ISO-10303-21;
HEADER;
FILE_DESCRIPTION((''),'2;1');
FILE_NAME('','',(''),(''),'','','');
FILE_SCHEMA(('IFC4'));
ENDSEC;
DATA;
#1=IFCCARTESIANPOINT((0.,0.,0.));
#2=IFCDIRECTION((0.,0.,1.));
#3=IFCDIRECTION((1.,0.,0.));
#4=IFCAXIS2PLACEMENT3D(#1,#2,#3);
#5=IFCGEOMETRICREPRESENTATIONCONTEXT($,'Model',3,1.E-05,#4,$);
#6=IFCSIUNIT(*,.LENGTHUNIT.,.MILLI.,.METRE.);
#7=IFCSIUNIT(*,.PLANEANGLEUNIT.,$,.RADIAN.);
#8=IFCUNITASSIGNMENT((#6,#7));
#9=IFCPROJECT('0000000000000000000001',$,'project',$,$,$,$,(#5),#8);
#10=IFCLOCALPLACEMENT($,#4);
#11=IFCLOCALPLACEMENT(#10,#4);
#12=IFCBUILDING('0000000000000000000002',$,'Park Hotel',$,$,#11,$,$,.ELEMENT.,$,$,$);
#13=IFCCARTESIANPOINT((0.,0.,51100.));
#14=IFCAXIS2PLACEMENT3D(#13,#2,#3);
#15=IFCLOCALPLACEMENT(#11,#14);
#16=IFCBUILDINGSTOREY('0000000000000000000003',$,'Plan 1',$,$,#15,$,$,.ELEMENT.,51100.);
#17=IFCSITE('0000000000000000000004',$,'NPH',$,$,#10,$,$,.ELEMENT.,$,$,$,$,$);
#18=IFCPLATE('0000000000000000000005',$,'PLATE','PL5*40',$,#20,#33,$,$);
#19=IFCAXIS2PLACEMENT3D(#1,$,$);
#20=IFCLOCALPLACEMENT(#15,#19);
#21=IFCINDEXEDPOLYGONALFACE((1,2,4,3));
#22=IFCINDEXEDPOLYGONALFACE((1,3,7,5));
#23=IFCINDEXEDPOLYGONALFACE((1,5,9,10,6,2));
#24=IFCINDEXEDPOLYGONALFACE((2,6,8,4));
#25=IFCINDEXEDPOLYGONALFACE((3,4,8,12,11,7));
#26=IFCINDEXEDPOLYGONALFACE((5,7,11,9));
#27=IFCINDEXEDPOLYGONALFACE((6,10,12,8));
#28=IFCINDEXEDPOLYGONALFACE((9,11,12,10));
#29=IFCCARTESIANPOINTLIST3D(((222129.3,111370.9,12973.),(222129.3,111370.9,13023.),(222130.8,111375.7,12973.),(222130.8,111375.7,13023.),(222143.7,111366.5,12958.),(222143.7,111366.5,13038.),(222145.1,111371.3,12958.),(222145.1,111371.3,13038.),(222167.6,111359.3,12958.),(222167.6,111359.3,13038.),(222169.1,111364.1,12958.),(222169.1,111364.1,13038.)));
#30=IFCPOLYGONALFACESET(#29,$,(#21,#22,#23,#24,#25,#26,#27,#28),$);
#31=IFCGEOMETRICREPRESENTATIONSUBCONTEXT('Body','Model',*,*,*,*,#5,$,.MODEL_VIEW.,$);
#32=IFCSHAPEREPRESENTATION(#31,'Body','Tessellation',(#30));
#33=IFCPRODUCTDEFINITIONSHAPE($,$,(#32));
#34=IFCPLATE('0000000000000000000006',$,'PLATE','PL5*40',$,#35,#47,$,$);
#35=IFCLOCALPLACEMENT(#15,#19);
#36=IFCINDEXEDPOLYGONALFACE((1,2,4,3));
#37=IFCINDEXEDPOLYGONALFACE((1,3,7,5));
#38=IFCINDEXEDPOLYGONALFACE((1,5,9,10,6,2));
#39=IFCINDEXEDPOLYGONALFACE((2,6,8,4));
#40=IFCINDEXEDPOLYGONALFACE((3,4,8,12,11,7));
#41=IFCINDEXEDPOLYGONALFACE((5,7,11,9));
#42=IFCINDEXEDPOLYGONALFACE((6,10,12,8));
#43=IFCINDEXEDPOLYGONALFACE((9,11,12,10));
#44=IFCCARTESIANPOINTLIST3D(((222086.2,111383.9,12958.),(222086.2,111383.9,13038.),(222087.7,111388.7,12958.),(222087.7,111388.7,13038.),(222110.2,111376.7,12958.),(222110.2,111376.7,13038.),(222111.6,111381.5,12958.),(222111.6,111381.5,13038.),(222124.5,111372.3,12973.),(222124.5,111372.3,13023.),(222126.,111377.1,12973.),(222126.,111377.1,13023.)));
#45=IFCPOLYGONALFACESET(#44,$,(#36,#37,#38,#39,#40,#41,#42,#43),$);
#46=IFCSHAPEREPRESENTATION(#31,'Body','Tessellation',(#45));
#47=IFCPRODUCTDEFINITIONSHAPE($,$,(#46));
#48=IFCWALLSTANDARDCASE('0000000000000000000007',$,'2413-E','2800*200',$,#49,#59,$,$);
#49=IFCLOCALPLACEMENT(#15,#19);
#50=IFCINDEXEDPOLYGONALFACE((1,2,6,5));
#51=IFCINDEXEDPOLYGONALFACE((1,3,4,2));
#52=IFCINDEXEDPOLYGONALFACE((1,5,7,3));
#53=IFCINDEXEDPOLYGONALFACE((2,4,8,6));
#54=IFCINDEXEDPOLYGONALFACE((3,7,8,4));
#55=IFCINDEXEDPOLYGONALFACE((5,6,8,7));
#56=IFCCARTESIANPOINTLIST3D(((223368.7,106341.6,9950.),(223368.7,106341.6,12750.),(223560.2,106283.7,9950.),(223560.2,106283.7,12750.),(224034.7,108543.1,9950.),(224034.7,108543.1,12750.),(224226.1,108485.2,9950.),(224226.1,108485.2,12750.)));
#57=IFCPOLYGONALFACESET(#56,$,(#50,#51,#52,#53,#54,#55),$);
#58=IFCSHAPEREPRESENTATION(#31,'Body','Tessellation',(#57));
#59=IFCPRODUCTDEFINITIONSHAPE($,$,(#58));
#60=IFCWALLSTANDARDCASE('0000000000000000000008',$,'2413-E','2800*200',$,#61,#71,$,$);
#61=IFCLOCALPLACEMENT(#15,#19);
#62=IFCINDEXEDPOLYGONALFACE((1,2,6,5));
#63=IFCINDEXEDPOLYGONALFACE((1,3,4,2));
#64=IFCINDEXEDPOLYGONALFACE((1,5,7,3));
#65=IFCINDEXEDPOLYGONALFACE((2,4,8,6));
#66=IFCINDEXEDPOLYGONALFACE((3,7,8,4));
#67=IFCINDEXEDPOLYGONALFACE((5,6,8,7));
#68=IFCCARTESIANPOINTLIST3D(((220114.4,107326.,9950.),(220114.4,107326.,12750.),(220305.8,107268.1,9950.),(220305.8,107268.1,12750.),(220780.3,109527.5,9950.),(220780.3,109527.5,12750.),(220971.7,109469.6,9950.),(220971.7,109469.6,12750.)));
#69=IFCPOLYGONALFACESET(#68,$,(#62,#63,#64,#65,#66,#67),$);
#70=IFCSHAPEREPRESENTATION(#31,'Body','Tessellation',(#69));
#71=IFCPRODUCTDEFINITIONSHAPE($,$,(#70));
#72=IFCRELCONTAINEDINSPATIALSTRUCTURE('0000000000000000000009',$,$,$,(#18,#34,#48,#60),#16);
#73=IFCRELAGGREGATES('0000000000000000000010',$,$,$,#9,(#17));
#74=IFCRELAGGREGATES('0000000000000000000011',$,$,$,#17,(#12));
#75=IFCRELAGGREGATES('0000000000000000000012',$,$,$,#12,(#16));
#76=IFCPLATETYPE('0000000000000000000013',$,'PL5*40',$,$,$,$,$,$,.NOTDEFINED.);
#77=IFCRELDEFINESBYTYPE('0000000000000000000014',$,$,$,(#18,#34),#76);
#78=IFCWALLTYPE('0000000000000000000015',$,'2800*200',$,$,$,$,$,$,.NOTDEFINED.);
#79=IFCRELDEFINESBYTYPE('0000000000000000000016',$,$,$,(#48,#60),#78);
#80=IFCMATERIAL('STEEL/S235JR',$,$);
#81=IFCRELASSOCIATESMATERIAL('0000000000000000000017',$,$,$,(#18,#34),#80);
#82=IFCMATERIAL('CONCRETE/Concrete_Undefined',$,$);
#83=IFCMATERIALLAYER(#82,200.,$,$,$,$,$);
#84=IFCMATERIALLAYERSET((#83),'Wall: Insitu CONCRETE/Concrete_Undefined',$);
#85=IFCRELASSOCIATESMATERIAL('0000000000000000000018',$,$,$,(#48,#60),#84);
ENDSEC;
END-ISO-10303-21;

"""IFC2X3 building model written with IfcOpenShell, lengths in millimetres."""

from ifc_helpers import new_model, si_unit, frame, frame_2d, origin_with_axes, place, context, subcontext, project, spatial, polyline, rectangle, outline, extrude, material, layer, layer_set, layer_usage, type_object, element, save


model = new_model("IFC2X3")

# Units and contexts
model_context = context("Model", 3, precision=1e-05, world=origin_with_axes())
body_context = subcontext(model_context, "Body", "Model", "MODEL_VIEW")
ifc_project = project(units=[si_unit("LENGTHUNIT", "METRE", prefix="MILLI"), si_unit("PLANEANGLEUNIT", "RADIAN")], contexts=[model_context])

# Site, building, storey
site_placement = place(None, origin_with_axes())
site = spatial("IfcSite", under=ifc_project, at=site_placement, Name="NPH", CompositionType="ELEMENT")
building_placement = place(site_placement, origin_with_axes())
building = spatial("IfcBuilding", under=site, at=building_placement, Name="Park Hotel", CompositionType="ELEMENT")
storey_placement = place(building_placement, frame((0.0, 0.0, 51100.0), z_axis=(0.0, 0.0, 1.0), x_axis=(1.0, 0.0, 0.0)))
storey = spatial("IfcBuildingStorey", under=building, at=storey_placement, Name="Plan 1", CompositionType="ELEMENT", Elevation=51100.0)

# Plates
ifc_material_1 = material(Name="STEEL/S235JR")
plate_type = type_object("IfcPlateType", Name="PL5*40", PredefinedType="NOTDEFINED")
plate_1_placement = place(storey_placement, frame((222168.3, 111361.7, 12958.0), z_axis=(0.289538, 0.957167, 0.0), x_axis=(-0.957167, 0.289538, 0.0)))
element("IfcPlate", 1, at=plate_1_placement, inside=storey, type_object=plate_type, material=ifc_material_1, Name="PLATE", Description="PL5*40", context=body_context, shape_type="SweptSolid", body=[
    extrude(outline(polyline([(0.0, 0.0), (25.0, 0.0), (40.0, 15.0), (40.0, 65.0), (25.0, 80.0), (0.0, 80.0), (0.0, 0.0)])), frame((0.0, 0.0, -2.5), z_axis=(0.0, 0.0, 1.0), x_axis=(1.0, 0.0, 0.0)), (0.0, 0.0, 1.0), 5.0),
])
plate_2_placement = place(storey_placement, frame((222125.3, 111374.7, 12958.0), z_axis=(0.289538, 0.957167, 0.0), x_axis=(-0.957167, 0.289538, 0.0)))
element("IfcPlate", 2, at=plate_2_placement, inside=storey, type_object=plate_type, material=ifc_material_1, Name="PLATE", Description="PL5*40", context=body_context, shape_type="SweptSolid", body=[
    extrude(outline(polyline([(0.0, 15.0), (15.0, 0.0), (40.0, 0.0), (40.0, 80.0), (15.0, 80.0), (0.0, 65.0), (0.0, 15.0)])), frame((0.0, 0.0, -2.5), z_axis=(0.0, 0.0, 1.0), x_axis=(1.0, 0.0, 0.0)), (0.0, 0.0, 1.0), 5.0),
])

# Walls
ifc_material_2 = material(Name="CONCRETE/Concrete_Undefined")
ifc_layer = layer(ifc_material_2, 200.0)
ifc_layer_set = layer_set([ifc_layer], Name="Wall: Insitu CONCRETE/Concrete_Undefined")
ifc_layer_usage_1 = layer_usage(ifc_layer_set, "AXIS2", "POSITIVE", -100.0)
wall_type = type_object("IfcWallType", Name="2800*200", PredefinedType="NOTDEFINED")
wall_1_placement = place(storey_placement, frame((223464.5, 106312.7, 9950.0), z_axis=(0.0, 0.0, 1.0), x_axis=(0.289536, 0.957167, 0.0)))
element("IfcWallStandardCase", 3, at=wall_1_placement, inside=storey, type_object=wall_type, material=ifc_layer_usage_1, Name="2413-E", Description="2800*200", context=body_context, shape_type="SweptSolid", body=[
    extrude(rectangle(XDim=2300.0, YDim=200.0, at=frame_2d((0.0, 1150.0), x_axis=(0.0, -1.0))), frame((0.0, 0.0, 0.0), z_axis=(0.0, 0.0, 1.0), x_axis=(0.0, -1.0, 0.0)), (0.0, 0.0, 1.0), 2800.0),
])
ifc_layer_usage_2 = layer_usage(ifc_layer_set, "AXIS2", "POSITIVE", -100.0)
wall_2_placement = place(storey_placement, frame((220210.1, 107297.1, 9950.0), z_axis=(0.0, 0.0, 1.0), x_axis=(0.289536, 0.957167, 0.0)))
element("IfcWallStandardCase", 4, at=wall_2_placement, inside=storey, type_object=wall_type, material=ifc_layer_usage_2, Name="2413-E", Description="2800*200", context=body_context, shape_type="SweptSolid", body=[
    extrude(rectangle(XDim=2300.0, YDim=200.0, at=frame_2d((0.0, 1150.0), x_axis=(0.0, -1.0))), frame((0.0, 0.0, 0.0), z_axis=(0.0, 0.0, 1.0), x_axis=(0.0, -1.0, 0.0)), (0.0, 0.0, 1.0), 2800.0),
])

save(model, "model.ifc")
